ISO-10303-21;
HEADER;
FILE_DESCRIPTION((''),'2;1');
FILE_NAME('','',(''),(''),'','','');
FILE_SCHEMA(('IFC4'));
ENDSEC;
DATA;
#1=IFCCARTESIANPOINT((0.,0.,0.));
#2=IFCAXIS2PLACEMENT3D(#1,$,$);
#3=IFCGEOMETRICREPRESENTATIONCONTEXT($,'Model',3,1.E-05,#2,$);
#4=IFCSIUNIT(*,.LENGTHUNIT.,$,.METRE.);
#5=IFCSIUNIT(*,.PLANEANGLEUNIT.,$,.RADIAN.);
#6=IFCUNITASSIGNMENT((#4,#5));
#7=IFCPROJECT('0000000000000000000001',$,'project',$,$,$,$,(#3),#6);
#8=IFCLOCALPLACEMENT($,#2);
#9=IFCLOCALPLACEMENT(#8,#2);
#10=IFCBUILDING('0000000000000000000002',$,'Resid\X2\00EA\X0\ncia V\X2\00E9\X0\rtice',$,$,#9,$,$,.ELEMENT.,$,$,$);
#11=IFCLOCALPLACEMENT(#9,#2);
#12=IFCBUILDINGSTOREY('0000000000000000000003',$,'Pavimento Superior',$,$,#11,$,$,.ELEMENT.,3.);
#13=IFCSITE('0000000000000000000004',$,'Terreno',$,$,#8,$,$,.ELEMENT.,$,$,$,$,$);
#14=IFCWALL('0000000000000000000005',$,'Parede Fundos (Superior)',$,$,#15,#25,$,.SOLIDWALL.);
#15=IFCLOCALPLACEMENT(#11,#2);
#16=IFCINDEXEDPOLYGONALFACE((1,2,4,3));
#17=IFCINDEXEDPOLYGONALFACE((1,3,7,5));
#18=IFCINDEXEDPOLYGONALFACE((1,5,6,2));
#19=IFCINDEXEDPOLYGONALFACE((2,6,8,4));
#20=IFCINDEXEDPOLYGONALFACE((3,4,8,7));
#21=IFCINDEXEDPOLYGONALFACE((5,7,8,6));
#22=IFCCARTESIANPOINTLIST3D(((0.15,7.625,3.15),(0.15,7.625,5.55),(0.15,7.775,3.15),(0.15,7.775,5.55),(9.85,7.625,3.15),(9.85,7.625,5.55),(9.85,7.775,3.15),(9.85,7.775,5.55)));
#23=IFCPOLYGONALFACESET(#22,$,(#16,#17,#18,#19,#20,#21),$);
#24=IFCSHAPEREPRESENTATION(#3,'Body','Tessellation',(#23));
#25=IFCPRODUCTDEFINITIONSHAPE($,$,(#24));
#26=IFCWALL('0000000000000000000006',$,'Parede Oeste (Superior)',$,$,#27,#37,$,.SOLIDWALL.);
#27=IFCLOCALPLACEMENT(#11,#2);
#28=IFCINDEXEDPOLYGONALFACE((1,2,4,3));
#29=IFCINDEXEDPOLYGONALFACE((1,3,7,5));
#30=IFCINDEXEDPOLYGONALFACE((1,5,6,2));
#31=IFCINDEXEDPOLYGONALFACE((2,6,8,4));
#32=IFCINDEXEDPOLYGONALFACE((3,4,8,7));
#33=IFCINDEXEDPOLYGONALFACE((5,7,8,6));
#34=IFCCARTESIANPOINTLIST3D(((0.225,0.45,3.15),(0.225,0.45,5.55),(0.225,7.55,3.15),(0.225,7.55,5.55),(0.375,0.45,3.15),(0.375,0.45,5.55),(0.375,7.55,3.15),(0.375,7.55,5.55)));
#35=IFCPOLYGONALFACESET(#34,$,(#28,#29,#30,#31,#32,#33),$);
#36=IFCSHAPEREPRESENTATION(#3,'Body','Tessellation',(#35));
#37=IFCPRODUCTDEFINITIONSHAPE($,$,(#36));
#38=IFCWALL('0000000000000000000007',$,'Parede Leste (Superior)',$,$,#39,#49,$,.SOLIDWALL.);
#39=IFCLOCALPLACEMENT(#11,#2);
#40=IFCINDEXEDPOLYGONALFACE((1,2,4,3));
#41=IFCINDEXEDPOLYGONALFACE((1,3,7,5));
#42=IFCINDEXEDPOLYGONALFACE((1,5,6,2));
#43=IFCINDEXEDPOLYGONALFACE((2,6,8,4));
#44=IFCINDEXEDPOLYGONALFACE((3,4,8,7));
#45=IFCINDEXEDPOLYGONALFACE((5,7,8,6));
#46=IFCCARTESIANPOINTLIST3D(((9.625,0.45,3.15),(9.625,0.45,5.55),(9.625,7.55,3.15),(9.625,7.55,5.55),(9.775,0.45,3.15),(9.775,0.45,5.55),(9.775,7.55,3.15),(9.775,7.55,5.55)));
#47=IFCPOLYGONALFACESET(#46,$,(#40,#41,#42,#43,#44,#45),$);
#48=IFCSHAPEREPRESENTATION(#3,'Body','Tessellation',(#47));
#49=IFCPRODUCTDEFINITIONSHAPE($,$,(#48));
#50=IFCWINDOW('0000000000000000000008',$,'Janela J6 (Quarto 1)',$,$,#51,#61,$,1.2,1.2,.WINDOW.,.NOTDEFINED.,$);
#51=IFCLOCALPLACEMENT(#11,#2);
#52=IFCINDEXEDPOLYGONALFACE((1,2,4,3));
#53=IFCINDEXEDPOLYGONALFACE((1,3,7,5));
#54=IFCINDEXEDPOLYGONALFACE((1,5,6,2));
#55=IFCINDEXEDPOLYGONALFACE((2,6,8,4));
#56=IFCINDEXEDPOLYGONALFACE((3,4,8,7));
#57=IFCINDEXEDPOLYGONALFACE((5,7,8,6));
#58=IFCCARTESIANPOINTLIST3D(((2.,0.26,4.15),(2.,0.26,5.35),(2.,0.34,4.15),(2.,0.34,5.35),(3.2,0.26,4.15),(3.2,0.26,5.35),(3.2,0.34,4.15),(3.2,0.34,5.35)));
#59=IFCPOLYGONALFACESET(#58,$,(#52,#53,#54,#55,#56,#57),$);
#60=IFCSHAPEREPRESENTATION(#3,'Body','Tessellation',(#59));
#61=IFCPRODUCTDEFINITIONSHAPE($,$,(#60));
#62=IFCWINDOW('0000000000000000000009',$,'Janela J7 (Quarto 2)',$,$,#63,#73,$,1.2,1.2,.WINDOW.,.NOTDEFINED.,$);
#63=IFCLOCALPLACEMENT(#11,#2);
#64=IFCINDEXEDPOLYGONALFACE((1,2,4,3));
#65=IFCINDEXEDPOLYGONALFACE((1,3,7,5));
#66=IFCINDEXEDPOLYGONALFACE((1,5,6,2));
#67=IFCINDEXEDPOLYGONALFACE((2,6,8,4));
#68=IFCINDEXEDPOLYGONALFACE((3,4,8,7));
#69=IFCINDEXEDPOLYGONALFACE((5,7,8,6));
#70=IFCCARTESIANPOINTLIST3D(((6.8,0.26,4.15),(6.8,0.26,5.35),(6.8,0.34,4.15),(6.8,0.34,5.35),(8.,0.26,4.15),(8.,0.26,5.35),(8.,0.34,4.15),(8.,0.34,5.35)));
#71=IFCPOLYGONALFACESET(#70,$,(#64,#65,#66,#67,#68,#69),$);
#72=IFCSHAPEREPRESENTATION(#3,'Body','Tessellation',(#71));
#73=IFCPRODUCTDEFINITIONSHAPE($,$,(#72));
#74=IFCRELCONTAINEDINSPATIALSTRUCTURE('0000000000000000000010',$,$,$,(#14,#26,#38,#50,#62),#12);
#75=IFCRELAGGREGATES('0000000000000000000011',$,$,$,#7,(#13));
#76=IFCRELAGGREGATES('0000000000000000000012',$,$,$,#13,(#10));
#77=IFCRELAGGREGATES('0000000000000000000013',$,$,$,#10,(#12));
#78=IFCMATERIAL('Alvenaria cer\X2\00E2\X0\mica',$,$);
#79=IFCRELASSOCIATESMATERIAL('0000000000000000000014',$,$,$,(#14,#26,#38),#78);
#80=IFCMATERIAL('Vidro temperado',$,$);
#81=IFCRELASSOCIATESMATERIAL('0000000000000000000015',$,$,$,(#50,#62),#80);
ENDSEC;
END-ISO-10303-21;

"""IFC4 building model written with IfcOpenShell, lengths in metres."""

from ifc_helpers import new_model, si_unit, frame, frame_2d, origin, place, context, project, spatial, rectangle, extrude, material, element, save


model = new_model("IFC4")

# Units and contexts
model_context = context("Model", 3, precision=1e-05, world=origin())
ifc_project = project(units=[si_unit("LENGTHUNIT", "METRE"), si_unit("PLANEANGLEUNIT", "RADIAN")], contexts=[model_context])

# Site, building, storey
site_placement = place(None, origin())
site = spatial("IfcSite", under=ifc_project, at=site_placement, Name="Terreno", CompositionType="ELEMENT")
building_placement = place(site_placement, origin())
building = spatial("IfcBuilding", under=site, at=building_placement, Name="Residência Vértice", CompositionType="ELEMENT")
storey_placement = place(building_placement, origin())
storey = spatial("IfcBuildingStorey", under=building, at=storey_placement, Name="Pavimento Superior", CompositionType="ELEMENT", Elevation=3.0)

# Walls
ifc_material_1 = material(Name="Alvenaria cerâmica")
wall_1_placement = place(storey_placement, origin())
element("IfcWall", 1, at=wall_1_placement, inside=storey, material=ifc_material_1, Name="Parede Fundos (Superior)", PredefinedType="SOLIDWALL", context=model_context, shape_type="SweptSolid", body=[
    extrude(rectangle(XDim=9.7, YDim=0.15, at=frame_2d((5.0, 7.7))), frame((0.0, 0.0, 3.15)), (0.0, 0.0, 1.0), 2.4),
])
wall_2_placement = place(storey_placement, origin())
element("IfcWall", 2, at=wall_2_placement, inside=storey, material=ifc_material_1, Name="Parede Oeste (Superior)", PredefinedType="SOLIDWALL", context=model_context, shape_type="SweptSolid", body=[
    extrude(rectangle(XDim=0.15, YDim=7.1, at=frame_2d((0.3, 4.0))), frame((0.0, 0.0, 3.15)), (0.0, 0.0, 1.0), 2.4),
])
wall_3_placement = place(storey_placement, origin())
element("IfcWall", 3, at=wall_3_placement, inside=storey, material=ifc_material_1, Name="Parede Leste (Superior)", PredefinedType="SOLIDWALL", context=model_context, shape_type="SweptSolid", body=[
    extrude(rectangle(XDim=0.15, YDim=7.1, at=frame_2d((9.7, 4.0))), frame((0.0, 0.0, 3.15)), (0.0, 0.0, 1.0), 2.4),
])

# Windows
ifc_material_2 = material(Name="Vidro temperado")
window_1_placement = place(storey_placement, origin())
element("IfcWindow", 4, at=window_1_placement, inside=storey, material=ifc_material_2, Name="Janela J6 (Quarto 1)", OverallHeight=1.2, OverallWidth=1.2, PartitioningType="NOTDEFINED", PredefinedType="WINDOW", context=model_context, shape_type="SweptSolid", body=[
    extrude(rectangle(XDim=1.2, YDim=0.08, at=frame_2d((2.6, 0.3))), frame((0.0, 0.0, 4.15)), (0.0, 0.0, 1.0), 1.2),
])
window_2_placement = place(storey_placement, origin())
element("IfcWindow", 5, at=window_2_placement, inside=storey, material=ifc_material_2, Name="Janela J7 (Quarto 2)", OverallHeight=1.2, OverallWidth=1.2, PartitioningType="NOTDEFINED", PredefinedType="WINDOW", context=model_context, shape_type="SweptSolid", body=[
    extrude(rectangle(XDim=1.2, YDim=0.08, at=frame_2d((7.4, 0.3))), frame((0.0, 0.0, 4.15)), (0.0, 0.0, 1.0), 1.2),
])

save(model, "model.ifc")
